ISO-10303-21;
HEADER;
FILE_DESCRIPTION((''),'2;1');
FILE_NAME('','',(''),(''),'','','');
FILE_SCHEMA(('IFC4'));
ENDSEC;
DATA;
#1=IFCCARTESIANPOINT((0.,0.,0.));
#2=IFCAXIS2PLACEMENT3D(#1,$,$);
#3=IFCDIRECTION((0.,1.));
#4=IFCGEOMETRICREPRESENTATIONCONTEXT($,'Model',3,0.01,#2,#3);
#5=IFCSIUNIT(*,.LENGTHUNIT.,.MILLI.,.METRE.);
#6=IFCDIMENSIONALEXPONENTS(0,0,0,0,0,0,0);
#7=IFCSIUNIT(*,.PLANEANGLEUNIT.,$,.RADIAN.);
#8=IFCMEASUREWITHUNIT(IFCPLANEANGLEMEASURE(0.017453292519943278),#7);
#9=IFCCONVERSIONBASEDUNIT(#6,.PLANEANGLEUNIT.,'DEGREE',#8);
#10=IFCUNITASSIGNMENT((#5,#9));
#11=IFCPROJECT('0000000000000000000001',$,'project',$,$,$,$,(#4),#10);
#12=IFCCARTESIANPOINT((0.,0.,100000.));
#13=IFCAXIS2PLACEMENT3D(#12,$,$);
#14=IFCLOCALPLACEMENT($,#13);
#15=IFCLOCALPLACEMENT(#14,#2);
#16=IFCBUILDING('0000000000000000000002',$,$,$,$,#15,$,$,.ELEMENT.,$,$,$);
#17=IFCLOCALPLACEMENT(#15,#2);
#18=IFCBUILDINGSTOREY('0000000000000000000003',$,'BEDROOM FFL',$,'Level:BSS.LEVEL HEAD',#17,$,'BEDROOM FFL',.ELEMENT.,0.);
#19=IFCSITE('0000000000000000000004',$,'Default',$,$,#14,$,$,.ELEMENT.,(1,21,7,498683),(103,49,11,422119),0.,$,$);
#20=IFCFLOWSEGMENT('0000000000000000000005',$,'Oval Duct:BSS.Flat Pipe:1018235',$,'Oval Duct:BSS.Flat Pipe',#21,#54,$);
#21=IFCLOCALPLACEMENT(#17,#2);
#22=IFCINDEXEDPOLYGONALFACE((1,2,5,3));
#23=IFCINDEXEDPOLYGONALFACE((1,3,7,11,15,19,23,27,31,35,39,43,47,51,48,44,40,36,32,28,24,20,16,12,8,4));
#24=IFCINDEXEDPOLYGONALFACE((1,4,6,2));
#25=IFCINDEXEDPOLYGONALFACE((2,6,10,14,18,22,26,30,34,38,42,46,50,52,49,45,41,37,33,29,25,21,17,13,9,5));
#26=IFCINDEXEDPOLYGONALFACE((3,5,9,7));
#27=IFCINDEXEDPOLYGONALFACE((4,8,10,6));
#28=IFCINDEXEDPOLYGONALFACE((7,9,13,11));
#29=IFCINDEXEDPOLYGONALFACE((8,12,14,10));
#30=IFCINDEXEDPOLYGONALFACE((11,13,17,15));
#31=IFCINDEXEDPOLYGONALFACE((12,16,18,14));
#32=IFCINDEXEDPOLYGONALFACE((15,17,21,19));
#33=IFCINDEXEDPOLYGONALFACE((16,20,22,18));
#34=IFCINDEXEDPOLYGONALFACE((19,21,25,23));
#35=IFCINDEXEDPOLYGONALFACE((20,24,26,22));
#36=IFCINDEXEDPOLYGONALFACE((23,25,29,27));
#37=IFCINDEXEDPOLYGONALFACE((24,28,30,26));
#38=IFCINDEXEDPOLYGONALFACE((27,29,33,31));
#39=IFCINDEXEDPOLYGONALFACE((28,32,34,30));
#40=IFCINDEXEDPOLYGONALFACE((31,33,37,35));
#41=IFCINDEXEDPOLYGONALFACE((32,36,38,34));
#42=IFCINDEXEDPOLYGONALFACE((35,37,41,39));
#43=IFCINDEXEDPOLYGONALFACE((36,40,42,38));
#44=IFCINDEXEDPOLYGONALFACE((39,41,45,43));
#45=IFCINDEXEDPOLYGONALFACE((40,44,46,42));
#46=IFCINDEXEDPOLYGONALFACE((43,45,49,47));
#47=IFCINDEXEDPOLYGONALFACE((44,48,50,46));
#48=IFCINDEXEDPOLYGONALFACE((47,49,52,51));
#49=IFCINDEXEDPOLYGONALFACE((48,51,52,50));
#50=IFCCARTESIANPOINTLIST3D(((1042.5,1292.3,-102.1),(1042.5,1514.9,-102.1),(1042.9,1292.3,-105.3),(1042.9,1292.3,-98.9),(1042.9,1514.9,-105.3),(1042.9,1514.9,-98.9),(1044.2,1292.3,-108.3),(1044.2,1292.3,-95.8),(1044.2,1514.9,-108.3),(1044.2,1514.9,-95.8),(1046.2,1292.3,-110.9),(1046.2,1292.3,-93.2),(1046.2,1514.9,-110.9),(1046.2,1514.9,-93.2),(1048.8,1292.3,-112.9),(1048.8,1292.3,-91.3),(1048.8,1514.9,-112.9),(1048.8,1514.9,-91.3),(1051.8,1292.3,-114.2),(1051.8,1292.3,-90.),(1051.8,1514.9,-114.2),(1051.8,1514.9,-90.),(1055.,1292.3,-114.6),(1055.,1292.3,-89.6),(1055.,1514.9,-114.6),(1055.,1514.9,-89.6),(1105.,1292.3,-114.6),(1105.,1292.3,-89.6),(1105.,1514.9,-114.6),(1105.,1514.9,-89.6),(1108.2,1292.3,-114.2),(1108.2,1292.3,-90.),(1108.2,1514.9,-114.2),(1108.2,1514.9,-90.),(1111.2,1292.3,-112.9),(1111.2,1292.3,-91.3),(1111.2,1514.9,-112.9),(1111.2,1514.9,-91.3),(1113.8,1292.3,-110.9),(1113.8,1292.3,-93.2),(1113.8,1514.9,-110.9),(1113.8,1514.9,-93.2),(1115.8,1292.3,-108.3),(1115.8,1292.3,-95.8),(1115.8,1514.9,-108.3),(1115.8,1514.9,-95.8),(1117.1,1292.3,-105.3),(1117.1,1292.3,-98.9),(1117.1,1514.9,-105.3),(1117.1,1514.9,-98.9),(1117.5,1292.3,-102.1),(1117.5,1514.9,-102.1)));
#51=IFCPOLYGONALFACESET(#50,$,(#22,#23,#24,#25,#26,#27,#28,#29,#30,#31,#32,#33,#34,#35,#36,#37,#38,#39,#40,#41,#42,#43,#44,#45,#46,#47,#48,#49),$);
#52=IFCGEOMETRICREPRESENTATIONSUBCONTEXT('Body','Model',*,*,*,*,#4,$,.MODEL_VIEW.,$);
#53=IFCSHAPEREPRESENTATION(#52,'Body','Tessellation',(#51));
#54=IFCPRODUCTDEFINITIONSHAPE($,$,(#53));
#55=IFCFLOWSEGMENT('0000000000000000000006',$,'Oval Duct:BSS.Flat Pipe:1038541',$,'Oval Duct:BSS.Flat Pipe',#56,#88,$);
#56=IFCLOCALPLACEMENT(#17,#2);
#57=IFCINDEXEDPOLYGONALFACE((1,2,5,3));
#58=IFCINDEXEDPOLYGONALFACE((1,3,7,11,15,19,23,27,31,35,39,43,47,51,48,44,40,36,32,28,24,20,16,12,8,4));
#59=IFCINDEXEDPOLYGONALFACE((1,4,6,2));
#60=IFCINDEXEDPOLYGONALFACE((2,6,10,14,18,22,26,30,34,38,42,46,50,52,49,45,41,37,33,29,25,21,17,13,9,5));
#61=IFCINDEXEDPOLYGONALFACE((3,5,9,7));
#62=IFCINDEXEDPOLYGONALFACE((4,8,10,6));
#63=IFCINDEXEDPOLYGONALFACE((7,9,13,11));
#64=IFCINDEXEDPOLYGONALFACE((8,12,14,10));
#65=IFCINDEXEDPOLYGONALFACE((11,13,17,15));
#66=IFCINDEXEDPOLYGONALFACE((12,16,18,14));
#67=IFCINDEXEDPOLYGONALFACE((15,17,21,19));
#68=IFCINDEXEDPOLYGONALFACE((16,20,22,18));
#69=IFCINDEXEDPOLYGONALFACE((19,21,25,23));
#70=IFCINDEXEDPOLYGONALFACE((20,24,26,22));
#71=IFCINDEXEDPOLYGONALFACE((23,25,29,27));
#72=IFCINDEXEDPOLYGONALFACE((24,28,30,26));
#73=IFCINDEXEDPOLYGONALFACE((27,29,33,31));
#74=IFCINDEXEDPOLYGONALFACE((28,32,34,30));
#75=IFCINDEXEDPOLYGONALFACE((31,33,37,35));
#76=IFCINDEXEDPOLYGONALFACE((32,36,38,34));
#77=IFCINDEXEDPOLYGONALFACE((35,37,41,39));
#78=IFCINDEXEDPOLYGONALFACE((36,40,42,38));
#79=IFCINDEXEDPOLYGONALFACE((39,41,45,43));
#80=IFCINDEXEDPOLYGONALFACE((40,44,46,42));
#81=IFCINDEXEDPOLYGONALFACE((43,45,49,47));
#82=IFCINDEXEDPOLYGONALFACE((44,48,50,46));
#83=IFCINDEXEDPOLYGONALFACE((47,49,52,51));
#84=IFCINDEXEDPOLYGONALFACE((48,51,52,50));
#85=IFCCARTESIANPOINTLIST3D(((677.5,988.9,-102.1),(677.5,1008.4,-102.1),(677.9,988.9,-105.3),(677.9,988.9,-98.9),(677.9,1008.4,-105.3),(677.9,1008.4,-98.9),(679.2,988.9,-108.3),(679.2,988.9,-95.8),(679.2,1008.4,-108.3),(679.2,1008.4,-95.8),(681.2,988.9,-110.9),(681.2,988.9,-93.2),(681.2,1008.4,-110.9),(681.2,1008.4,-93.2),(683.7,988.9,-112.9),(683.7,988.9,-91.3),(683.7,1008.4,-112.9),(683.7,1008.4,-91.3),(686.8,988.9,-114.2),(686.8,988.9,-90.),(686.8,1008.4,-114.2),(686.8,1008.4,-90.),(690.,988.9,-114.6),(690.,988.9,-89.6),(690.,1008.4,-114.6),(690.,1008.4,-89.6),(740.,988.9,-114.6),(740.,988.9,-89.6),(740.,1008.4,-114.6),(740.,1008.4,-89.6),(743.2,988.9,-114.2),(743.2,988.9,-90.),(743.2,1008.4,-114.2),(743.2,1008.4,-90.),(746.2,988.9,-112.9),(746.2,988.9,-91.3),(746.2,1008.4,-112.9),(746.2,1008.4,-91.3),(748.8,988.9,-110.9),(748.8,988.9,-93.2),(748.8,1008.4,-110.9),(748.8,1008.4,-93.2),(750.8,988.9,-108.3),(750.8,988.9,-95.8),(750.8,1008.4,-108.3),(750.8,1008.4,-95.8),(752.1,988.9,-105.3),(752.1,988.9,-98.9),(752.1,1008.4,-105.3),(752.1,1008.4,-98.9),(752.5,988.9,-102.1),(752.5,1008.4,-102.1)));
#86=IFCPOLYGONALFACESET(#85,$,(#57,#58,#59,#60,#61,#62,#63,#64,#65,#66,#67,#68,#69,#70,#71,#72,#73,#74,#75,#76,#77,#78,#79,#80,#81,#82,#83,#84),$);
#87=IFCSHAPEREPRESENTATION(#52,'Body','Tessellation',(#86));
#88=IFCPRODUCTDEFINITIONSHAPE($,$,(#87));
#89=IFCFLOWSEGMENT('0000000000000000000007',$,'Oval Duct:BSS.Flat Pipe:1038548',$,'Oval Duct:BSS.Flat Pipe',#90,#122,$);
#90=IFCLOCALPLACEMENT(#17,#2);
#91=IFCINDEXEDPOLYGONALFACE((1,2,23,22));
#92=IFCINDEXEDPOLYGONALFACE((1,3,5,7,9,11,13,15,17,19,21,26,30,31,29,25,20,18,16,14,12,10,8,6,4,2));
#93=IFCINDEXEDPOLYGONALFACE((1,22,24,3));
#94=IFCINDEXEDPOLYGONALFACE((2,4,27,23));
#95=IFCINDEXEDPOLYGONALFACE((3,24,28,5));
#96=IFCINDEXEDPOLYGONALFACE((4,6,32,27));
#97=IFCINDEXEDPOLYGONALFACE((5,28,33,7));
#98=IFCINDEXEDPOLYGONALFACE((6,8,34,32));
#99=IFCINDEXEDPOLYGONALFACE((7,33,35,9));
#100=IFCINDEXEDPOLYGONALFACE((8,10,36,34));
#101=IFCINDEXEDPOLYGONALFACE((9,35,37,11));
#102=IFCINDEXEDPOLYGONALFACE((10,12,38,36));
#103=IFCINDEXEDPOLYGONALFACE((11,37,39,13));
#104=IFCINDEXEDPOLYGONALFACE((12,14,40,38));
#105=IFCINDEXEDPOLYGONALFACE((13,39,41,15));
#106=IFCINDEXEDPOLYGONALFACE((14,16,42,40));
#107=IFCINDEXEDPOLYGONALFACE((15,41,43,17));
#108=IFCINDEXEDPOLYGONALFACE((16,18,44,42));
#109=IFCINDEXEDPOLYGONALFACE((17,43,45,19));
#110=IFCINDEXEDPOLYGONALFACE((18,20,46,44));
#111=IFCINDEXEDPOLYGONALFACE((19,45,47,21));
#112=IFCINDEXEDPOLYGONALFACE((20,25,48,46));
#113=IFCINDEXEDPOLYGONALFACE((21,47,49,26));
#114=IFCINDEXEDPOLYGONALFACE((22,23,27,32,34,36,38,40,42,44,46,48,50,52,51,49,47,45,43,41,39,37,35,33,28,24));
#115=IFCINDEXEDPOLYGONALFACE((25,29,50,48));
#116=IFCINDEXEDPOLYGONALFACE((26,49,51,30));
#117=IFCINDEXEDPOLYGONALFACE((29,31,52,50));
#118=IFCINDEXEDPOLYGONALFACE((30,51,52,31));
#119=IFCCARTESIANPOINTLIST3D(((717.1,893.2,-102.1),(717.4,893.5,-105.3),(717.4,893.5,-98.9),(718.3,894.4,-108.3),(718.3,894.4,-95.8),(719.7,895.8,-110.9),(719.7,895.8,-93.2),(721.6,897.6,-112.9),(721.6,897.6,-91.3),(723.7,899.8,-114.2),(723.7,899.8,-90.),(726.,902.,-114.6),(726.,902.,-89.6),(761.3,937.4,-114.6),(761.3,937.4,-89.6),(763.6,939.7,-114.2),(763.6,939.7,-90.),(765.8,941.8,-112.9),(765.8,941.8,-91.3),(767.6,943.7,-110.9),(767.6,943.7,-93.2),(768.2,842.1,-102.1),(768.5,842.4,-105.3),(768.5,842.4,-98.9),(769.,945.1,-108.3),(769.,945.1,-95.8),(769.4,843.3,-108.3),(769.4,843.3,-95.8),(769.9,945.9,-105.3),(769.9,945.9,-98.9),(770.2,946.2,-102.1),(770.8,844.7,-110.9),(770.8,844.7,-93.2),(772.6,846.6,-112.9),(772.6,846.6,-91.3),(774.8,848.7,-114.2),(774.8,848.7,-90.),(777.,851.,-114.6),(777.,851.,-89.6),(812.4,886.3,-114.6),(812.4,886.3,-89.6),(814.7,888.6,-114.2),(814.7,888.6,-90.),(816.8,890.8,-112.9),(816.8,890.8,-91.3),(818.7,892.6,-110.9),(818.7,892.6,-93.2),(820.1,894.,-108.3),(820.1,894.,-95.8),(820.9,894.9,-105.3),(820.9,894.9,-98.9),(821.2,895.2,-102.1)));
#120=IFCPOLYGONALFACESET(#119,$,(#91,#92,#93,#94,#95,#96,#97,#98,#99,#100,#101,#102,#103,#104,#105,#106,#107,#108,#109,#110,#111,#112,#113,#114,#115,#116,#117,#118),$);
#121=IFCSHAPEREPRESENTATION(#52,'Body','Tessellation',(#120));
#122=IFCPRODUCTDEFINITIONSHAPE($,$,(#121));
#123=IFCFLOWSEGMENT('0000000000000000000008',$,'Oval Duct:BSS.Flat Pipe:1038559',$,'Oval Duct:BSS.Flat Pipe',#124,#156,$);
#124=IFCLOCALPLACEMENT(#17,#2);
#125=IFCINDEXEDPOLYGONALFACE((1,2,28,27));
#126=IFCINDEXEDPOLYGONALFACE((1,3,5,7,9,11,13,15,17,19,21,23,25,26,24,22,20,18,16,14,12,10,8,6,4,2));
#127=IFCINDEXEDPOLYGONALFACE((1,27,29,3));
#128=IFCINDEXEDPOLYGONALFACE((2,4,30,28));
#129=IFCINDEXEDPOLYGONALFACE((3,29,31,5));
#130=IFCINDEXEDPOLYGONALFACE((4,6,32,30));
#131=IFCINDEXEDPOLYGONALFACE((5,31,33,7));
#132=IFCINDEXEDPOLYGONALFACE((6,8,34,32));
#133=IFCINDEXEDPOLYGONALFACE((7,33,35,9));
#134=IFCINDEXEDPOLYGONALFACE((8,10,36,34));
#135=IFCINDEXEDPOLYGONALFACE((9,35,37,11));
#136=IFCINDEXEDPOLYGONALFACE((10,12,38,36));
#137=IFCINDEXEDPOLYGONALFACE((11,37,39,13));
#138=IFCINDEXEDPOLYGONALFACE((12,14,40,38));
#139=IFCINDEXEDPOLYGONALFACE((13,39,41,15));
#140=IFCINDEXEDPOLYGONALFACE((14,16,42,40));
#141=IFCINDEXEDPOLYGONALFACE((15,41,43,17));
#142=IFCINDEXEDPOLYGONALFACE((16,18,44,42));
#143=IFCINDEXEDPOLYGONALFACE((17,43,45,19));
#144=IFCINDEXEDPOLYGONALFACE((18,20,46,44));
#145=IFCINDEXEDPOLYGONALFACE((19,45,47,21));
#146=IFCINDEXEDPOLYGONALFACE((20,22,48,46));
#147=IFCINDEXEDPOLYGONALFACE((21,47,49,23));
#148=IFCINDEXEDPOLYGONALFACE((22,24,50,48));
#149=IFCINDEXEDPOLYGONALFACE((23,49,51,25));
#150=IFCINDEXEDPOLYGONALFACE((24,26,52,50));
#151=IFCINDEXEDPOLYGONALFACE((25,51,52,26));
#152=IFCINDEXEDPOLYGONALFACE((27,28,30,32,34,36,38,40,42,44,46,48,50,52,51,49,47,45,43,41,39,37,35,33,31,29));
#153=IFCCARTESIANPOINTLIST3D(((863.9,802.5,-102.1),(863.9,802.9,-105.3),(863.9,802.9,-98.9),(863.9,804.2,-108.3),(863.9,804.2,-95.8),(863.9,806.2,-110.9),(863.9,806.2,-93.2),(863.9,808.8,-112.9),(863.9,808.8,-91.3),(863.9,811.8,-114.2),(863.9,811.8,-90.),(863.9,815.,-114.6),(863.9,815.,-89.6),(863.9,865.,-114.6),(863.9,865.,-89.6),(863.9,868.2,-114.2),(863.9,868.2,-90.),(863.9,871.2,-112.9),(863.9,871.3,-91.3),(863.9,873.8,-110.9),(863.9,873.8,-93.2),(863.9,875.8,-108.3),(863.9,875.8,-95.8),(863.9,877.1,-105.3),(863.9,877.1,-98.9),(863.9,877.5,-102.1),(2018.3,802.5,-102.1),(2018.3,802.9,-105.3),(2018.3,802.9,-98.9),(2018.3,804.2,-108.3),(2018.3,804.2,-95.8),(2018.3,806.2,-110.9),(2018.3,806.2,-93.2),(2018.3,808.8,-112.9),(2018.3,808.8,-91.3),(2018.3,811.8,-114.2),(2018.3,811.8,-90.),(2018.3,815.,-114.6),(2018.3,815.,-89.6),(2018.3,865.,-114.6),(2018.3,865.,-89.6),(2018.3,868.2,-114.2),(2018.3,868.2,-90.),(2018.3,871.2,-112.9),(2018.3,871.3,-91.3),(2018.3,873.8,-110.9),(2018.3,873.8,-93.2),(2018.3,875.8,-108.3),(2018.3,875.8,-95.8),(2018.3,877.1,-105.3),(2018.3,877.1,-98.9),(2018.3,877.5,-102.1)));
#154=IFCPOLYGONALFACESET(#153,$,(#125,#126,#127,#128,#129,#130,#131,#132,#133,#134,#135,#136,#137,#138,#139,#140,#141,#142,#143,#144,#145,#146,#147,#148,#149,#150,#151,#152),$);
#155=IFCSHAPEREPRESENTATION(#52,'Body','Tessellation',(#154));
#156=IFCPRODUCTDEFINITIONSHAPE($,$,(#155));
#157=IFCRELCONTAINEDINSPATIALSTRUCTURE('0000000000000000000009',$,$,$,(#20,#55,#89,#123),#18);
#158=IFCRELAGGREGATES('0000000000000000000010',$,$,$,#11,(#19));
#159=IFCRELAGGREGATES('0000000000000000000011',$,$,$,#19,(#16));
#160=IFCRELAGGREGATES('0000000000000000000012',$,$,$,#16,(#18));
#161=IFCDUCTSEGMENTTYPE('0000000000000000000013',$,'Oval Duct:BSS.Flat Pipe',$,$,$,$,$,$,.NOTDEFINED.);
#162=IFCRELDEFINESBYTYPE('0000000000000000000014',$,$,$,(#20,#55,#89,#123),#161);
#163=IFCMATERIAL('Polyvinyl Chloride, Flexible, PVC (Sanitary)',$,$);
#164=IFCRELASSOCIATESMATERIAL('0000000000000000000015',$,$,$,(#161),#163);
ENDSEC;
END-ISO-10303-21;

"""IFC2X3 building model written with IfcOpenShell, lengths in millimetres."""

from ifc_helpers import new_model, entity, si_unit, converted_unit, direction, frame, frame_2d, origin, place, context, subcontext, project, spatial, polyline, circle_curve, parameter, trimmed, segment, composite_curve, outline, extrude, material, type_object, element, save


model = new_model("IFC2X3")

# Units and contexts
model_context = context("Model", 3, precision=0.01, world=origin(), true_north=direction((0.0, 1.0)))
body_context = subcontext(model_context, "Body", "Model", "MODEL_VIEW")
ifc_project = project(units=[si_unit("LENGTHUNIT", "METRE", prefix="MILLI"), converted_unit("PLANEANGLEUNIT", "DEGREE", entity("IfcPlaneAngleMeasure", 0.017453292519943278), si_unit("PLANEANGLEUNIT", "RADIAN"), dimensions=[0, 0, 0, 0, 0, 0, 0])], contexts=[model_context])

# Site, building, storey
site_placement = place(None, frame((0.0, 0.0, 100000.0)))
site = spatial("IfcSite", under=ifc_project, at=site_placement, Name="Default", CompositionType="ELEMENT", RefLatitude=(1, 21, 7, 498683), RefLongitude=(103, 49, 11, 422119), RefElevation=0.0)
building_placement = place(site_placement, origin())
building = spatial("IfcBuilding", under=site, at=building_placement, CompositionType="ELEMENT")
storey_placement = place(building_placement, origin())
storey = spatial("IfcBuildingStorey", under=building, at=storey_placement, Name="BEDROOM FFL", ObjectType="Level:BSS.LEVEL HEAD", LongName="BEDROOM FFL", CompositionType="ELEMENT", Elevation=0.0)

# Flow segments
ifc_material_1 = material(Name="Polyvinyl Chloride, Flexible, PVC (Sanitary)")
duct_segment_type = type_object("IfcDuctSegmentType", Name="Oval Duct:BSS.Flat Pipe", PredefinedType="NOTDEFINED", material=ifc_material_1)
flow_segment_1_placement = place(storey_placement, origin())
element("IfcFlowSegment", 1, at=flow_segment_1_placement, inside=storey, type_object=duct_segment_type, Name="Oval Duct:BSS.Flat Pipe:1018235", ObjectType="Oval Duct:BSS.Flat Pipe", context=body_context, shape_type="SweptSolid", body=[
    extrude(outline(composite_curve([segment(trimmed(circle_curve(frame_2d((25.0, 0.0), x_axis=(1.0, 0.0)), 12.5), [parameter(270.0)], [parameter(0.0)], True, "PARAMETER"), True, "CONTINUOUS"), segment(trimmed(circle_curve(frame_2d((25.0, 0.0), x_axis=(1.0, 0.0)), 12.5), [parameter(0.0)], [parameter(90.0)], True, "PARAMETER"), True, "CONTINUOUS"), segment(polyline([(25.0, 12.5), (-25.0, 12.5)]), True, "CONTINUOUS"), segment(trimmed(circle_curve(frame_2d((-25.0, 0.0), x_axis=(1.0, 0.0)), 12.5), [parameter(90.0)], [parameter(180.0)], True, "PARAMETER"), True, "CONTINUOUS"), segment(trimmed(circle_curve(frame_2d((-25.0, 0.0), x_axis=(1.0, 0.0)), 12.5), [parameter(180.0)], [parameter(270.0)], True, "PARAMETER"), True, "CONTINUOUS"), segment(polyline([(-25.0, -12.5), (25.0, -12.5)]), True, "CONTINUOUS")], self_intersect=False)), frame((1080.0, 1292.3, -102.1), z_axis=(0.0, 1.0, 0.0), x_axis=(1.0, 0.0, 0.0)), (0.0, 0.0, 1.0), 222.6),
])
flow_segment_2_placement = place(storey_placement, origin())
element("IfcFlowSegment", 2, at=flow_segment_2_placement, inside=storey, type_object=duct_segment_type, Name="Oval Duct:BSS.Flat Pipe:1038541", ObjectType="Oval Duct:BSS.Flat Pipe", context=body_context, shape_type="SweptSolid", body=[
    extrude(outline(composite_curve([segment(polyline([(-25.0, -12.5), (25.0, -12.5)]), True, "CONTINUOUS"), segment(trimmed(circle_curve(frame_2d((25.0, 0.0), x_axis=(-1.0, 0.0)), 12.5), [parameter(90.0)], [parameter(180.0)], True, "PARAMETER"), True, "CONTINUOUS"), segment(trimmed(circle_curve(frame_2d((25.0, 0.0), x_axis=(-1.0, 0.0)), 12.5), [parameter(180.0)], [parameter(270.0)], True, "PARAMETER"), True, "CONTINUOUS"), segment(polyline([(25.0, 12.5), (-25.0, 12.5)]), True, "CONTINUOUS"), segment(trimmed(circle_curve(frame_2d((-25.0, 0.0), x_axis=(-1.0, 0.0)), 12.5), [parameter(270.0)], [parameter(0.0)], True, "PARAMETER"), True, "CONTINUOUS"), segment(trimmed(circle_curve(frame_2d((-25.0, 0.0), x_axis=(-1.0, 0.0)), 12.5), [parameter(0.0)], [parameter(90.0)], True, "PARAMETER"), True, "CONTINUOUS")], self_intersect=False)), frame((715.0, 988.9, -102.1), z_axis=(0.0, 1.0, 0.0), x_axis=(1.0, 0.0, 0.0)), (0.0, 0.0, 1.0), 19.5),
])
flow_segment_3_placement = place(storey_placement, origin())
element("IfcFlowSegment", 3, at=flow_segment_3_placement, inside=storey, type_object=duct_segment_type, Name="Oval Duct:BSS.Flat Pipe:1038548", ObjectType="Oval Duct:BSS.Flat Pipe", context=body_context, shape_type="SweptSolid", body=[
    extrude(outline(composite_curve([segment(polyline([(-25.0, -12.5), (25.0, -12.5)]), True, "CONTINUOUS"), segment(trimmed(circle_curve(frame_2d((25.0, 0.0), x_axis=(-1.0, 0.0)), 12.5), [parameter(90.0)], [parameter(180.0)], True, "PARAMETER"), True, "CONTINUOUS"), segment(trimmed(circle_curve(frame_2d((25.0, 0.0), x_axis=(-1.0, 0.0)), 12.5), [parameter(180.0)], [parameter(270.0)], True, "PARAMETER"), True, "CONTINUOUS"), segment(polyline([(25.0, 12.5), (-25.0, 12.5)]), True, "CONTINUOUS"), segment(trimmed(circle_curve(frame_2d((-25.0, 0.0), x_axis=(-1.0, 0.0)), 12.5), [parameter(270.0)], [parameter(0.0)], True, "PARAMETER"), True, "CONTINUOUS"), segment(trimmed(circle_curve(frame_2d((-25.0, 0.0), x_axis=(-1.0, 0.0)), 12.5), [parameter(0.0)], [parameter(90.0)], True, "PARAMETER"), True, "CONTINUOUS")], self_intersect=False)), frame((794.7, 868.7, -102.1), z_axis=(-0.707107, 0.707107, 0.0), x_axis=(0.707107, 0.707107, 0.0)), (0.0, 0.0, 1.0), 72.2),
])
flow_segment_4_placement = place(storey_placement, origin())
element("IfcFlowSegment", 4, at=flow_segment_4_placement, inside=storey, type_object=duct_segment_type, Name="Oval Duct:BSS.Flat Pipe:1038559", ObjectType="Oval Duct:BSS.Flat Pipe", context=body_context, shape_type="SweptSolid", body=[
    extrude(outline(composite_curve([segment(trimmed(circle_curve(frame_2d((25.0, 0.0), x_axis=(1.0, 0.0)), 12.5), [parameter(270.0)], [parameter(0.0)], True, "PARAMETER"), True, "CONTINUOUS"), segment(trimmed(circle_curve(frame_2d((25.0, 0.0), x_axis=(1.0, 0.0)), 12.5), [parameter(0.0)], [parameter(90.0)], True, "PARAMETER"), True, "CONTINUOUS"), segment(polyline([(25.0, 12.5), (-25.0, 12.5)]), True, "CONTINUOUS"), segment(trimmed(circle_curve(frame_2d((-25.0, 0.0), x_axis=(1.0, 0.0)), 12.5), [parameter(90.0)], [parameter(180.0)], True, "PARAMETER"), True, "CONTINUOUS"), segment(trimmed(circle_curve(frame_2d((-25.0, 0.0), x_axis=(1.0, 0.0)), 12.5), [parameter(180.0)], [parameter(270.0)], True, "PARAMETER"), True, "CONTINUOUS"), segment(polyline([(-25.0, -12.5), (25.0, -12.5)]), True, "CONTINUOUS")], self_intersect=False)), frame((863.9, 840.0, -102.1), z_axis=(1.0, 0.0, 0.0), x_axis=(0.0, -1.0, 0.0)), (0.0, 0.0, 1.0), 1154.4),
])

save(model, "model.ifc")
